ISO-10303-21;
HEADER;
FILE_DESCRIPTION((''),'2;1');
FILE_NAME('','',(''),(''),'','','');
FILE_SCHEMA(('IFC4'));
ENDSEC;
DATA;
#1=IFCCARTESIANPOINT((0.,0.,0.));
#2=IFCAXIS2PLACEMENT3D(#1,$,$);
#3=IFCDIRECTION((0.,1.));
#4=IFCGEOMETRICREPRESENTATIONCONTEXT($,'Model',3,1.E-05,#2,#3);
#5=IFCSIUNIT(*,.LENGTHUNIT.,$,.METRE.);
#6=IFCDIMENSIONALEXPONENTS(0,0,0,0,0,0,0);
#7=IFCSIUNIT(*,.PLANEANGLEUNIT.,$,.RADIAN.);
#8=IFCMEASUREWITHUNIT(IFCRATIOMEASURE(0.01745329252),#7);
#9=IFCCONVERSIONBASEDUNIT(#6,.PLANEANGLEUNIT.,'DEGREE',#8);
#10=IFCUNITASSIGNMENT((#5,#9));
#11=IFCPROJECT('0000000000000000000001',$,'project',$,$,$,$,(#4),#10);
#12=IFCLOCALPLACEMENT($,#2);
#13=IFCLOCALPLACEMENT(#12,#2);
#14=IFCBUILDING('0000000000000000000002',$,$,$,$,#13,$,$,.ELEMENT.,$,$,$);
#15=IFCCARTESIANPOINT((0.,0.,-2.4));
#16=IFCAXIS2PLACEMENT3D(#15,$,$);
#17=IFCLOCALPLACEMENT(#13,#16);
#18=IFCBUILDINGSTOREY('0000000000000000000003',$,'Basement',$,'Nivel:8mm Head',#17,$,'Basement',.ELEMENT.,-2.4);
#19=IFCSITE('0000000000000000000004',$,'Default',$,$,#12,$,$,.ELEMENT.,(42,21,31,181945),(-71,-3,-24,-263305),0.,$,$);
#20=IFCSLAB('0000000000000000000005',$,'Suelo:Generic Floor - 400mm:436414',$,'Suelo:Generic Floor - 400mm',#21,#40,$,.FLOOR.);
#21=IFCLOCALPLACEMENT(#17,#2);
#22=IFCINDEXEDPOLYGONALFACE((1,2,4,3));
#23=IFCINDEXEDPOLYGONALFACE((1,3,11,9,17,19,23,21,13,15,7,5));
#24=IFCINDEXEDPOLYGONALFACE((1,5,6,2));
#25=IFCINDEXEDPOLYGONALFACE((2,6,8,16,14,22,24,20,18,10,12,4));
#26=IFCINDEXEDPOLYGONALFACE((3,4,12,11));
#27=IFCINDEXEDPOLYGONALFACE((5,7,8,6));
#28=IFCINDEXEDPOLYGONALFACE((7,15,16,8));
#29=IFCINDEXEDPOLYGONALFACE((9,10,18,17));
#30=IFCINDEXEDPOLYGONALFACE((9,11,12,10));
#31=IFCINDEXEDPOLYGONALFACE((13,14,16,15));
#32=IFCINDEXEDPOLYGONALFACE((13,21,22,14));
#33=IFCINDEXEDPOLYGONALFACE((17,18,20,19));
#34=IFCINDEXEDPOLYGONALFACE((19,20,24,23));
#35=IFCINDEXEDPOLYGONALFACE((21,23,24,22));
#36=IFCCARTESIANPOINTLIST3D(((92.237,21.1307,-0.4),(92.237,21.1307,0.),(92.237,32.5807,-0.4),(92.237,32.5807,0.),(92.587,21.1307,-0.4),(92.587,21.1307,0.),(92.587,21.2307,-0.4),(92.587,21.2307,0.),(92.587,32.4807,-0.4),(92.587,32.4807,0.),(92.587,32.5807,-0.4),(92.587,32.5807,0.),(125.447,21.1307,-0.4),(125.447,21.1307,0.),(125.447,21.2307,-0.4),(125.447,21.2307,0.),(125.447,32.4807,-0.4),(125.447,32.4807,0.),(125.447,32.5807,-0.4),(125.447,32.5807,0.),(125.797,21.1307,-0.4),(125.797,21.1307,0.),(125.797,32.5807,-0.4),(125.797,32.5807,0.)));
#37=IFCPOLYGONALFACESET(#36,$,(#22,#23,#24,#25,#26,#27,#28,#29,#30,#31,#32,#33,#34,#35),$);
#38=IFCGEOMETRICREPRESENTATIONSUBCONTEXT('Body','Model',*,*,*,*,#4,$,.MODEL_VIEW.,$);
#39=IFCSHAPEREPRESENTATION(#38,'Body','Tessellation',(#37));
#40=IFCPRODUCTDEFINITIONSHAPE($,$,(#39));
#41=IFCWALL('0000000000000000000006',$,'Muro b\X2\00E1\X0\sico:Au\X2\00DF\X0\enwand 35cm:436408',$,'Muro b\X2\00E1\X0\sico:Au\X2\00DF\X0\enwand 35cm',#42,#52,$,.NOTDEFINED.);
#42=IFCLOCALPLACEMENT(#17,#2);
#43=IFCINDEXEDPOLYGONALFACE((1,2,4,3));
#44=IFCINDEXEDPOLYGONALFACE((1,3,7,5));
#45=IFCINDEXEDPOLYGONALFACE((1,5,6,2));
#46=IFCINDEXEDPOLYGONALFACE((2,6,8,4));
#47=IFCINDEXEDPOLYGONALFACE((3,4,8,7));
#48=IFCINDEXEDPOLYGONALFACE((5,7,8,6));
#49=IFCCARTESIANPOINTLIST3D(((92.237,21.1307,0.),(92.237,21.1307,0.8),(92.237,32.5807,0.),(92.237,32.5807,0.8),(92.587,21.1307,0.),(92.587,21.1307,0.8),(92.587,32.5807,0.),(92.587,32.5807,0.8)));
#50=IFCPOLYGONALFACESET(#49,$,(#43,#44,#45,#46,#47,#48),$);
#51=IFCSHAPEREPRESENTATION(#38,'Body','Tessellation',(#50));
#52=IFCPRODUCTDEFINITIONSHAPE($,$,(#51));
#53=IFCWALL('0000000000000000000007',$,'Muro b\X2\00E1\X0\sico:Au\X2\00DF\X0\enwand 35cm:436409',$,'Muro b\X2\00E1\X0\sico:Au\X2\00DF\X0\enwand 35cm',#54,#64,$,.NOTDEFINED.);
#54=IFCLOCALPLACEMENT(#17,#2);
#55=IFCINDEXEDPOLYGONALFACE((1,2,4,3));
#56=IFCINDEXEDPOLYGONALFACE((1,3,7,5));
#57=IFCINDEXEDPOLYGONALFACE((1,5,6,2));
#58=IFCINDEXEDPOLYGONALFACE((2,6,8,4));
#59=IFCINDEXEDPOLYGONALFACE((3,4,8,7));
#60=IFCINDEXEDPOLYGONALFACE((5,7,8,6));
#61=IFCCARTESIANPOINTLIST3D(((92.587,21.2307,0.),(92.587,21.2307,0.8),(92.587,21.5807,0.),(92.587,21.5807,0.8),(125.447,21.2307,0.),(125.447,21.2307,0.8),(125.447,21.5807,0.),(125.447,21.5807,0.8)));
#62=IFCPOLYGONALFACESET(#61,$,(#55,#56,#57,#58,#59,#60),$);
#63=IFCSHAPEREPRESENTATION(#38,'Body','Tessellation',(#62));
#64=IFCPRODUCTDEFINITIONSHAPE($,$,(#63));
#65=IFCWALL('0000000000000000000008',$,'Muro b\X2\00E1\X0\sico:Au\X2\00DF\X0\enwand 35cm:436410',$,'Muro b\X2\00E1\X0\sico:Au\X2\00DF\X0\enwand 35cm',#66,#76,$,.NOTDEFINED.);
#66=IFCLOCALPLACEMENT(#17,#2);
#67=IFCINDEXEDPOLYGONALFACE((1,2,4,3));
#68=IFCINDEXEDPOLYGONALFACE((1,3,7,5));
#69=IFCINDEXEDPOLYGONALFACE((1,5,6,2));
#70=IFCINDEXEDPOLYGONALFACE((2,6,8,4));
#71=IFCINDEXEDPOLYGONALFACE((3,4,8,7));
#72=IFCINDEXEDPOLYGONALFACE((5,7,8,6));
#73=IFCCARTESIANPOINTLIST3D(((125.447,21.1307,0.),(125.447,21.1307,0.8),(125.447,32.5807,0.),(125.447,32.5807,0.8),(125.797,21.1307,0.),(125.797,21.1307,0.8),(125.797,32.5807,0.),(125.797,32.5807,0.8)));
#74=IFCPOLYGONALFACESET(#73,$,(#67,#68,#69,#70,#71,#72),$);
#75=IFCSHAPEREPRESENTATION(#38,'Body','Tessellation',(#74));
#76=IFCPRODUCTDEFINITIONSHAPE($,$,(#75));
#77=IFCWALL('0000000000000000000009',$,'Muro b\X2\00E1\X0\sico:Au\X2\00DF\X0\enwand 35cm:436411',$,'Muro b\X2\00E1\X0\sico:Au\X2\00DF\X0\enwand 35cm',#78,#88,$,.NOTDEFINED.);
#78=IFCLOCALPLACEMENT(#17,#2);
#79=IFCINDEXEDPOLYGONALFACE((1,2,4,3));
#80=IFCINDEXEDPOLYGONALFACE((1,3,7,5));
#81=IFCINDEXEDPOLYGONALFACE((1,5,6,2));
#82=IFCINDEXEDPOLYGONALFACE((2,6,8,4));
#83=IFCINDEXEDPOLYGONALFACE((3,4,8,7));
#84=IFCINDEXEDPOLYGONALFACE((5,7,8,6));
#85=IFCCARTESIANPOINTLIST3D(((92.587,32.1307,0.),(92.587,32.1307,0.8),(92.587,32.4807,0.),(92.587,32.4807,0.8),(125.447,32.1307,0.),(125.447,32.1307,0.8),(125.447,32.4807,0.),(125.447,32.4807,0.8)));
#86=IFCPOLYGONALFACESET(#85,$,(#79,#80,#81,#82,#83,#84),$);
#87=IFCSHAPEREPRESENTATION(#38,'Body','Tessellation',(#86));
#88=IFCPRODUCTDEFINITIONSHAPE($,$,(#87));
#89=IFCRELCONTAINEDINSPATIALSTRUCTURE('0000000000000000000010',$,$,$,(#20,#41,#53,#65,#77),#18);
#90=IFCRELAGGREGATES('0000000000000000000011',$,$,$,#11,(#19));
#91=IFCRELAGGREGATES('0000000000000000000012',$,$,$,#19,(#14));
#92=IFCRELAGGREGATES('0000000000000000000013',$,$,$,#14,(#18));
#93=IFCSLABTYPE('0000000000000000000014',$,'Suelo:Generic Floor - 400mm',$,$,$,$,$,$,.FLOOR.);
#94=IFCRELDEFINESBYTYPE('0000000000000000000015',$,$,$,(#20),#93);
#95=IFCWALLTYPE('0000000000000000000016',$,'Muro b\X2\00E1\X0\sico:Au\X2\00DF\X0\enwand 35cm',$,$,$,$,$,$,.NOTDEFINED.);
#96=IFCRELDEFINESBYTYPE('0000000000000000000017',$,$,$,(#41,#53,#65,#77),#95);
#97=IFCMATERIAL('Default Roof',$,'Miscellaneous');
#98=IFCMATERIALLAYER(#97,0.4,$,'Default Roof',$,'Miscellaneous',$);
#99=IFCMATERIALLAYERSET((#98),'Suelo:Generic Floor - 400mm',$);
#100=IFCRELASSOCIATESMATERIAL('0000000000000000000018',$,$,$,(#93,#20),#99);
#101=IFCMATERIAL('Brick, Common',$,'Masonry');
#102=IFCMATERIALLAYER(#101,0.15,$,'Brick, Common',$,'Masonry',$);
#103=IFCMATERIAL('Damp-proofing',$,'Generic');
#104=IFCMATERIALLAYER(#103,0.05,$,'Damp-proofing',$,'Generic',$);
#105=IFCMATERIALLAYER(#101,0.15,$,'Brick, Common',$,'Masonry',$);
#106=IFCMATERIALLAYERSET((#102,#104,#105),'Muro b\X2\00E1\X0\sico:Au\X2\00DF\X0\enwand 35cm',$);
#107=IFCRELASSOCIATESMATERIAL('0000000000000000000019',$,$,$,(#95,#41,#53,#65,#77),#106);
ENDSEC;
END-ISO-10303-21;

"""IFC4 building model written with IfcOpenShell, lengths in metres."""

from ifc_helpers import new_model, entity, si_unit, converted_unit, direction, frame, frame_2d, origin, origin_2d_with_axis, place, context, subcontext, project, spatial, rectangle, i_section, extrude, material, layer, layer_set, layer_usage, type_object, element, save


model = new_model("IFC4")

# Units and contexts
model_context = context("Model", 3, precision=1e-05, world=origin(), true_north=direction((0.0, 1.0)))
body_context = subcontext(model_context, "Body", "Model", "MODEL_VIEW")
ifc_project = project(units=[si_unit("LENGTHUNIT", "METRE"), converted_unit("PLANEANGLEUNIT", "DEGREE", entity("IfcRatioMeasure", 0.01745329252), si_unit("PLANEANGLEUNIT", "RADIAN"), dimensions=[0, 0, 0, 0, 0, 0, 0])], contexts=[model_context])

# Site, building, storey
site_placement = place(None, origin())
site = spatial("IfcSite", under=ifc_project, at=site_placement, Name="Default", CompositionType="ELEMENT", RefLatitude=(42, 21, 31, 181945), RefLongitude=(-71, -3, -24, -263305), RefElevation=0.0)
building_placement = place(site_placement, origin())
building = spatial("IfcBuilding", under=site, at=building_placement, CompositionType="ELEMENT")
storey_placement = place(building_placement, frame((0.0, 0.0, -2.4)))
storey = spatial("IfcBuildingStorey", under=building, at=storey_placement, Name="Basement", ObjectType="Nivel:8mm Head", LongName="Basement", CompositionType="ELEMENT", Elevation=-2.4)

# Slab
ifc_material_1 = material(Name="Default Roof", Category="Miscellaneous")
ifc_layer_1 = layer(ifc_material_1, 0.4, Name="Default Roof", Category="Miscellaneous")
ifc_layer_set_1 = layer_set([ifc_layer_1], Name="Suelo:Generic Floor - 400mm")
ifc_layer_usage_1 = layer_usage(ifc_layer_set_1, "AXIS3", "POSITIVE", 0.0)
slab_type = type_object("IfcSlabType", Name="Suelo:Generic Floor - 400mm", PredefinedType="FLOOR", material=ifc_layer_set_1)
slab_placement = place(storey_placement, origin())
element("IfcSlab", 1, at=slab_placement, inside=storey, type_object=slab_type, material=ifc_layer_usage_1, Name="Suelo:Generic Floor - 400mm:436414", ObjectType="Suelo:Generic Floor - 400mm", PredefinedType="FLOOR", context=body_context, shape_type="SweptSolid", body=[
    extrude(i_section(OverallWidth=11.45, OverallDepth=33.56, WebThickness=11.25, FlangeThickness=0.35, at=origin_2d_with_axis()), frame((109.017, 26.8557, 0.0), z_axis=(0.0, 0.0, -1.0), x_axis=(0.0, 1.0, 0.0)), (0.0, 0.0, 1.0), 0.4),
])

# Walls
ifc_material_2 = material(Name="Brick, Common", Category="Masonry")
ifc_layer_2 = layer(ifc_material_2, 0.15, Name="Brick, Common", Category="Masonry")
ifc_material_3 = material(Name="Damp-proofing", Category="Generic")
ifc_layer_3 = layer(ifc_material_3, 0.05, Name="Damp-proofing", Category="Generic")
ifc_layer_4 = layer(ifc_material_2, 0.15, Name="Brick, Common", Category="Masonry")
ifc_layer_set_2 = layer_set([ifc_layer_2, ifc_layer_3, ifc_layer_4], Name="Muro básico:Außenwand 35cm")
ifc_layer_usage_2 = layer_usage(ifc_layer_set_2, "AXIS2", "NEGATIVE", 0.175)
wall_type = type_object("IfcWallType", Name="Muro básico:Außenwand 35cm", PredefinedType="NOTDEFINED", material=ifc_layer_set_2)
wall_1_placement = place(storey_placement, frame((92.412, 32.5807, 0.0), z_axis=(0.0, 0.0, 1.0), x_axis=(0.0, -1.0, 0.0)))
element("IfcWall", 2, at=wall_1_placement, inside=storey, type_object=wall_type, material=ifc_layer_usage_2, Name="Muro básico:Außenwand 35cm:436408", ObjectType="Muro básico:Außenwand 35cm", PredefinedType="NOTDEFINED", context=body_context, shape_type="SweptSolid", body=[
    extrude(rectangle(XDim=11.45, YDim=0.35, at=frame_2d((5.725, 0.0), x_axis=(-1.0, 0.0))), origin(), (0.0, 0.0, 1.0), 0.8),
])
ifc_layer_usage_3 = layer_usage(ifc_layer_set_2, "AXIS2", "NEGATIVE", 0.175)
wall_2_placement = place(storey_placement, frame((92.587, 21.4057, 0.0)))
element("IfcWall", 3, at=wall_2_placement, inside=storey, type_object=wall_type, material=ifc_layer_usage_3, Name="Muro básico:Außenwand 35cm:436409", ObjectType="Muro básico:Außenwand 35cm", PredefinedType="NOTDEFINED", context=body_context, shape_type="SweptSolid", body=[
    extrude(rectangle(XDim=32.86, YDim=0.35, at=frame_2d((16.43, 0.0), x_axis=(-1.0, 0.0))), origin(), (0.0, 0.0, 1.0), 0.8),
])
ifc_layer_usage_4 = layer_usage(ifc_layer_set_2, "AXIS2", "NEGATIVE", 0.175)
wall_3_placement = place(storey_placement, frame((125.622, 21.1307, 0.0), z_axis=(0.0, 0.0, 1.0), x_axis=(0.0, 1.0, 0.0)))
element("IfcWall", 4, at=wall_3_placement, inside=storey, type_object=wall_type, material=ifc_layer_usage_4, Name="Muro básico:Außenwand 35cm:436410", ObjectType="Muro básico:Außenwand 35cm", PredefinedType="NOTDEFINED", context=body_context, shape_type="SweptSolid", body=[
    extrude(rectangle(XDim=11.45, YDim=0.35, at=frame_2d((5.725, 0.0), x_axis=(-1.0, 0.0))), origin(), (0.0, 0.0, 1.0), 0.8),
])
ifc_layer_usage_5 = layer_usage(ifc_layer_set_2, "AXIS2", "NEGATIVE", 0.175)
wall_4_placement = place(storey_placement, frame((125.447, 32.3057, 0.0), z_axis=(0.0, 0.0, 1.0), x_axis=(-1.0, 0.0, 0.0)))
element("IfcWall", 5, at=wall_4_placement, inside=storey, type_object=wall_type, material=ifc_layer_usage_5, Name="Muro básico:Außenwand 35cm:436411", ObjectType="Muro básico:Außenwand 35cm", PredefinedType="NOTDEFINED", context=body_context, shape_type="SweptSolid", body=[
    extrude(rectangle(XDim=32.86, YDim=0.35, at=frame_2d((16.43, 0.0), x_axis=(-1.0, 0.0))), origin(), (0.0, 0.0, 1.0), 0.8),
])

save(model, "model.ifc")
